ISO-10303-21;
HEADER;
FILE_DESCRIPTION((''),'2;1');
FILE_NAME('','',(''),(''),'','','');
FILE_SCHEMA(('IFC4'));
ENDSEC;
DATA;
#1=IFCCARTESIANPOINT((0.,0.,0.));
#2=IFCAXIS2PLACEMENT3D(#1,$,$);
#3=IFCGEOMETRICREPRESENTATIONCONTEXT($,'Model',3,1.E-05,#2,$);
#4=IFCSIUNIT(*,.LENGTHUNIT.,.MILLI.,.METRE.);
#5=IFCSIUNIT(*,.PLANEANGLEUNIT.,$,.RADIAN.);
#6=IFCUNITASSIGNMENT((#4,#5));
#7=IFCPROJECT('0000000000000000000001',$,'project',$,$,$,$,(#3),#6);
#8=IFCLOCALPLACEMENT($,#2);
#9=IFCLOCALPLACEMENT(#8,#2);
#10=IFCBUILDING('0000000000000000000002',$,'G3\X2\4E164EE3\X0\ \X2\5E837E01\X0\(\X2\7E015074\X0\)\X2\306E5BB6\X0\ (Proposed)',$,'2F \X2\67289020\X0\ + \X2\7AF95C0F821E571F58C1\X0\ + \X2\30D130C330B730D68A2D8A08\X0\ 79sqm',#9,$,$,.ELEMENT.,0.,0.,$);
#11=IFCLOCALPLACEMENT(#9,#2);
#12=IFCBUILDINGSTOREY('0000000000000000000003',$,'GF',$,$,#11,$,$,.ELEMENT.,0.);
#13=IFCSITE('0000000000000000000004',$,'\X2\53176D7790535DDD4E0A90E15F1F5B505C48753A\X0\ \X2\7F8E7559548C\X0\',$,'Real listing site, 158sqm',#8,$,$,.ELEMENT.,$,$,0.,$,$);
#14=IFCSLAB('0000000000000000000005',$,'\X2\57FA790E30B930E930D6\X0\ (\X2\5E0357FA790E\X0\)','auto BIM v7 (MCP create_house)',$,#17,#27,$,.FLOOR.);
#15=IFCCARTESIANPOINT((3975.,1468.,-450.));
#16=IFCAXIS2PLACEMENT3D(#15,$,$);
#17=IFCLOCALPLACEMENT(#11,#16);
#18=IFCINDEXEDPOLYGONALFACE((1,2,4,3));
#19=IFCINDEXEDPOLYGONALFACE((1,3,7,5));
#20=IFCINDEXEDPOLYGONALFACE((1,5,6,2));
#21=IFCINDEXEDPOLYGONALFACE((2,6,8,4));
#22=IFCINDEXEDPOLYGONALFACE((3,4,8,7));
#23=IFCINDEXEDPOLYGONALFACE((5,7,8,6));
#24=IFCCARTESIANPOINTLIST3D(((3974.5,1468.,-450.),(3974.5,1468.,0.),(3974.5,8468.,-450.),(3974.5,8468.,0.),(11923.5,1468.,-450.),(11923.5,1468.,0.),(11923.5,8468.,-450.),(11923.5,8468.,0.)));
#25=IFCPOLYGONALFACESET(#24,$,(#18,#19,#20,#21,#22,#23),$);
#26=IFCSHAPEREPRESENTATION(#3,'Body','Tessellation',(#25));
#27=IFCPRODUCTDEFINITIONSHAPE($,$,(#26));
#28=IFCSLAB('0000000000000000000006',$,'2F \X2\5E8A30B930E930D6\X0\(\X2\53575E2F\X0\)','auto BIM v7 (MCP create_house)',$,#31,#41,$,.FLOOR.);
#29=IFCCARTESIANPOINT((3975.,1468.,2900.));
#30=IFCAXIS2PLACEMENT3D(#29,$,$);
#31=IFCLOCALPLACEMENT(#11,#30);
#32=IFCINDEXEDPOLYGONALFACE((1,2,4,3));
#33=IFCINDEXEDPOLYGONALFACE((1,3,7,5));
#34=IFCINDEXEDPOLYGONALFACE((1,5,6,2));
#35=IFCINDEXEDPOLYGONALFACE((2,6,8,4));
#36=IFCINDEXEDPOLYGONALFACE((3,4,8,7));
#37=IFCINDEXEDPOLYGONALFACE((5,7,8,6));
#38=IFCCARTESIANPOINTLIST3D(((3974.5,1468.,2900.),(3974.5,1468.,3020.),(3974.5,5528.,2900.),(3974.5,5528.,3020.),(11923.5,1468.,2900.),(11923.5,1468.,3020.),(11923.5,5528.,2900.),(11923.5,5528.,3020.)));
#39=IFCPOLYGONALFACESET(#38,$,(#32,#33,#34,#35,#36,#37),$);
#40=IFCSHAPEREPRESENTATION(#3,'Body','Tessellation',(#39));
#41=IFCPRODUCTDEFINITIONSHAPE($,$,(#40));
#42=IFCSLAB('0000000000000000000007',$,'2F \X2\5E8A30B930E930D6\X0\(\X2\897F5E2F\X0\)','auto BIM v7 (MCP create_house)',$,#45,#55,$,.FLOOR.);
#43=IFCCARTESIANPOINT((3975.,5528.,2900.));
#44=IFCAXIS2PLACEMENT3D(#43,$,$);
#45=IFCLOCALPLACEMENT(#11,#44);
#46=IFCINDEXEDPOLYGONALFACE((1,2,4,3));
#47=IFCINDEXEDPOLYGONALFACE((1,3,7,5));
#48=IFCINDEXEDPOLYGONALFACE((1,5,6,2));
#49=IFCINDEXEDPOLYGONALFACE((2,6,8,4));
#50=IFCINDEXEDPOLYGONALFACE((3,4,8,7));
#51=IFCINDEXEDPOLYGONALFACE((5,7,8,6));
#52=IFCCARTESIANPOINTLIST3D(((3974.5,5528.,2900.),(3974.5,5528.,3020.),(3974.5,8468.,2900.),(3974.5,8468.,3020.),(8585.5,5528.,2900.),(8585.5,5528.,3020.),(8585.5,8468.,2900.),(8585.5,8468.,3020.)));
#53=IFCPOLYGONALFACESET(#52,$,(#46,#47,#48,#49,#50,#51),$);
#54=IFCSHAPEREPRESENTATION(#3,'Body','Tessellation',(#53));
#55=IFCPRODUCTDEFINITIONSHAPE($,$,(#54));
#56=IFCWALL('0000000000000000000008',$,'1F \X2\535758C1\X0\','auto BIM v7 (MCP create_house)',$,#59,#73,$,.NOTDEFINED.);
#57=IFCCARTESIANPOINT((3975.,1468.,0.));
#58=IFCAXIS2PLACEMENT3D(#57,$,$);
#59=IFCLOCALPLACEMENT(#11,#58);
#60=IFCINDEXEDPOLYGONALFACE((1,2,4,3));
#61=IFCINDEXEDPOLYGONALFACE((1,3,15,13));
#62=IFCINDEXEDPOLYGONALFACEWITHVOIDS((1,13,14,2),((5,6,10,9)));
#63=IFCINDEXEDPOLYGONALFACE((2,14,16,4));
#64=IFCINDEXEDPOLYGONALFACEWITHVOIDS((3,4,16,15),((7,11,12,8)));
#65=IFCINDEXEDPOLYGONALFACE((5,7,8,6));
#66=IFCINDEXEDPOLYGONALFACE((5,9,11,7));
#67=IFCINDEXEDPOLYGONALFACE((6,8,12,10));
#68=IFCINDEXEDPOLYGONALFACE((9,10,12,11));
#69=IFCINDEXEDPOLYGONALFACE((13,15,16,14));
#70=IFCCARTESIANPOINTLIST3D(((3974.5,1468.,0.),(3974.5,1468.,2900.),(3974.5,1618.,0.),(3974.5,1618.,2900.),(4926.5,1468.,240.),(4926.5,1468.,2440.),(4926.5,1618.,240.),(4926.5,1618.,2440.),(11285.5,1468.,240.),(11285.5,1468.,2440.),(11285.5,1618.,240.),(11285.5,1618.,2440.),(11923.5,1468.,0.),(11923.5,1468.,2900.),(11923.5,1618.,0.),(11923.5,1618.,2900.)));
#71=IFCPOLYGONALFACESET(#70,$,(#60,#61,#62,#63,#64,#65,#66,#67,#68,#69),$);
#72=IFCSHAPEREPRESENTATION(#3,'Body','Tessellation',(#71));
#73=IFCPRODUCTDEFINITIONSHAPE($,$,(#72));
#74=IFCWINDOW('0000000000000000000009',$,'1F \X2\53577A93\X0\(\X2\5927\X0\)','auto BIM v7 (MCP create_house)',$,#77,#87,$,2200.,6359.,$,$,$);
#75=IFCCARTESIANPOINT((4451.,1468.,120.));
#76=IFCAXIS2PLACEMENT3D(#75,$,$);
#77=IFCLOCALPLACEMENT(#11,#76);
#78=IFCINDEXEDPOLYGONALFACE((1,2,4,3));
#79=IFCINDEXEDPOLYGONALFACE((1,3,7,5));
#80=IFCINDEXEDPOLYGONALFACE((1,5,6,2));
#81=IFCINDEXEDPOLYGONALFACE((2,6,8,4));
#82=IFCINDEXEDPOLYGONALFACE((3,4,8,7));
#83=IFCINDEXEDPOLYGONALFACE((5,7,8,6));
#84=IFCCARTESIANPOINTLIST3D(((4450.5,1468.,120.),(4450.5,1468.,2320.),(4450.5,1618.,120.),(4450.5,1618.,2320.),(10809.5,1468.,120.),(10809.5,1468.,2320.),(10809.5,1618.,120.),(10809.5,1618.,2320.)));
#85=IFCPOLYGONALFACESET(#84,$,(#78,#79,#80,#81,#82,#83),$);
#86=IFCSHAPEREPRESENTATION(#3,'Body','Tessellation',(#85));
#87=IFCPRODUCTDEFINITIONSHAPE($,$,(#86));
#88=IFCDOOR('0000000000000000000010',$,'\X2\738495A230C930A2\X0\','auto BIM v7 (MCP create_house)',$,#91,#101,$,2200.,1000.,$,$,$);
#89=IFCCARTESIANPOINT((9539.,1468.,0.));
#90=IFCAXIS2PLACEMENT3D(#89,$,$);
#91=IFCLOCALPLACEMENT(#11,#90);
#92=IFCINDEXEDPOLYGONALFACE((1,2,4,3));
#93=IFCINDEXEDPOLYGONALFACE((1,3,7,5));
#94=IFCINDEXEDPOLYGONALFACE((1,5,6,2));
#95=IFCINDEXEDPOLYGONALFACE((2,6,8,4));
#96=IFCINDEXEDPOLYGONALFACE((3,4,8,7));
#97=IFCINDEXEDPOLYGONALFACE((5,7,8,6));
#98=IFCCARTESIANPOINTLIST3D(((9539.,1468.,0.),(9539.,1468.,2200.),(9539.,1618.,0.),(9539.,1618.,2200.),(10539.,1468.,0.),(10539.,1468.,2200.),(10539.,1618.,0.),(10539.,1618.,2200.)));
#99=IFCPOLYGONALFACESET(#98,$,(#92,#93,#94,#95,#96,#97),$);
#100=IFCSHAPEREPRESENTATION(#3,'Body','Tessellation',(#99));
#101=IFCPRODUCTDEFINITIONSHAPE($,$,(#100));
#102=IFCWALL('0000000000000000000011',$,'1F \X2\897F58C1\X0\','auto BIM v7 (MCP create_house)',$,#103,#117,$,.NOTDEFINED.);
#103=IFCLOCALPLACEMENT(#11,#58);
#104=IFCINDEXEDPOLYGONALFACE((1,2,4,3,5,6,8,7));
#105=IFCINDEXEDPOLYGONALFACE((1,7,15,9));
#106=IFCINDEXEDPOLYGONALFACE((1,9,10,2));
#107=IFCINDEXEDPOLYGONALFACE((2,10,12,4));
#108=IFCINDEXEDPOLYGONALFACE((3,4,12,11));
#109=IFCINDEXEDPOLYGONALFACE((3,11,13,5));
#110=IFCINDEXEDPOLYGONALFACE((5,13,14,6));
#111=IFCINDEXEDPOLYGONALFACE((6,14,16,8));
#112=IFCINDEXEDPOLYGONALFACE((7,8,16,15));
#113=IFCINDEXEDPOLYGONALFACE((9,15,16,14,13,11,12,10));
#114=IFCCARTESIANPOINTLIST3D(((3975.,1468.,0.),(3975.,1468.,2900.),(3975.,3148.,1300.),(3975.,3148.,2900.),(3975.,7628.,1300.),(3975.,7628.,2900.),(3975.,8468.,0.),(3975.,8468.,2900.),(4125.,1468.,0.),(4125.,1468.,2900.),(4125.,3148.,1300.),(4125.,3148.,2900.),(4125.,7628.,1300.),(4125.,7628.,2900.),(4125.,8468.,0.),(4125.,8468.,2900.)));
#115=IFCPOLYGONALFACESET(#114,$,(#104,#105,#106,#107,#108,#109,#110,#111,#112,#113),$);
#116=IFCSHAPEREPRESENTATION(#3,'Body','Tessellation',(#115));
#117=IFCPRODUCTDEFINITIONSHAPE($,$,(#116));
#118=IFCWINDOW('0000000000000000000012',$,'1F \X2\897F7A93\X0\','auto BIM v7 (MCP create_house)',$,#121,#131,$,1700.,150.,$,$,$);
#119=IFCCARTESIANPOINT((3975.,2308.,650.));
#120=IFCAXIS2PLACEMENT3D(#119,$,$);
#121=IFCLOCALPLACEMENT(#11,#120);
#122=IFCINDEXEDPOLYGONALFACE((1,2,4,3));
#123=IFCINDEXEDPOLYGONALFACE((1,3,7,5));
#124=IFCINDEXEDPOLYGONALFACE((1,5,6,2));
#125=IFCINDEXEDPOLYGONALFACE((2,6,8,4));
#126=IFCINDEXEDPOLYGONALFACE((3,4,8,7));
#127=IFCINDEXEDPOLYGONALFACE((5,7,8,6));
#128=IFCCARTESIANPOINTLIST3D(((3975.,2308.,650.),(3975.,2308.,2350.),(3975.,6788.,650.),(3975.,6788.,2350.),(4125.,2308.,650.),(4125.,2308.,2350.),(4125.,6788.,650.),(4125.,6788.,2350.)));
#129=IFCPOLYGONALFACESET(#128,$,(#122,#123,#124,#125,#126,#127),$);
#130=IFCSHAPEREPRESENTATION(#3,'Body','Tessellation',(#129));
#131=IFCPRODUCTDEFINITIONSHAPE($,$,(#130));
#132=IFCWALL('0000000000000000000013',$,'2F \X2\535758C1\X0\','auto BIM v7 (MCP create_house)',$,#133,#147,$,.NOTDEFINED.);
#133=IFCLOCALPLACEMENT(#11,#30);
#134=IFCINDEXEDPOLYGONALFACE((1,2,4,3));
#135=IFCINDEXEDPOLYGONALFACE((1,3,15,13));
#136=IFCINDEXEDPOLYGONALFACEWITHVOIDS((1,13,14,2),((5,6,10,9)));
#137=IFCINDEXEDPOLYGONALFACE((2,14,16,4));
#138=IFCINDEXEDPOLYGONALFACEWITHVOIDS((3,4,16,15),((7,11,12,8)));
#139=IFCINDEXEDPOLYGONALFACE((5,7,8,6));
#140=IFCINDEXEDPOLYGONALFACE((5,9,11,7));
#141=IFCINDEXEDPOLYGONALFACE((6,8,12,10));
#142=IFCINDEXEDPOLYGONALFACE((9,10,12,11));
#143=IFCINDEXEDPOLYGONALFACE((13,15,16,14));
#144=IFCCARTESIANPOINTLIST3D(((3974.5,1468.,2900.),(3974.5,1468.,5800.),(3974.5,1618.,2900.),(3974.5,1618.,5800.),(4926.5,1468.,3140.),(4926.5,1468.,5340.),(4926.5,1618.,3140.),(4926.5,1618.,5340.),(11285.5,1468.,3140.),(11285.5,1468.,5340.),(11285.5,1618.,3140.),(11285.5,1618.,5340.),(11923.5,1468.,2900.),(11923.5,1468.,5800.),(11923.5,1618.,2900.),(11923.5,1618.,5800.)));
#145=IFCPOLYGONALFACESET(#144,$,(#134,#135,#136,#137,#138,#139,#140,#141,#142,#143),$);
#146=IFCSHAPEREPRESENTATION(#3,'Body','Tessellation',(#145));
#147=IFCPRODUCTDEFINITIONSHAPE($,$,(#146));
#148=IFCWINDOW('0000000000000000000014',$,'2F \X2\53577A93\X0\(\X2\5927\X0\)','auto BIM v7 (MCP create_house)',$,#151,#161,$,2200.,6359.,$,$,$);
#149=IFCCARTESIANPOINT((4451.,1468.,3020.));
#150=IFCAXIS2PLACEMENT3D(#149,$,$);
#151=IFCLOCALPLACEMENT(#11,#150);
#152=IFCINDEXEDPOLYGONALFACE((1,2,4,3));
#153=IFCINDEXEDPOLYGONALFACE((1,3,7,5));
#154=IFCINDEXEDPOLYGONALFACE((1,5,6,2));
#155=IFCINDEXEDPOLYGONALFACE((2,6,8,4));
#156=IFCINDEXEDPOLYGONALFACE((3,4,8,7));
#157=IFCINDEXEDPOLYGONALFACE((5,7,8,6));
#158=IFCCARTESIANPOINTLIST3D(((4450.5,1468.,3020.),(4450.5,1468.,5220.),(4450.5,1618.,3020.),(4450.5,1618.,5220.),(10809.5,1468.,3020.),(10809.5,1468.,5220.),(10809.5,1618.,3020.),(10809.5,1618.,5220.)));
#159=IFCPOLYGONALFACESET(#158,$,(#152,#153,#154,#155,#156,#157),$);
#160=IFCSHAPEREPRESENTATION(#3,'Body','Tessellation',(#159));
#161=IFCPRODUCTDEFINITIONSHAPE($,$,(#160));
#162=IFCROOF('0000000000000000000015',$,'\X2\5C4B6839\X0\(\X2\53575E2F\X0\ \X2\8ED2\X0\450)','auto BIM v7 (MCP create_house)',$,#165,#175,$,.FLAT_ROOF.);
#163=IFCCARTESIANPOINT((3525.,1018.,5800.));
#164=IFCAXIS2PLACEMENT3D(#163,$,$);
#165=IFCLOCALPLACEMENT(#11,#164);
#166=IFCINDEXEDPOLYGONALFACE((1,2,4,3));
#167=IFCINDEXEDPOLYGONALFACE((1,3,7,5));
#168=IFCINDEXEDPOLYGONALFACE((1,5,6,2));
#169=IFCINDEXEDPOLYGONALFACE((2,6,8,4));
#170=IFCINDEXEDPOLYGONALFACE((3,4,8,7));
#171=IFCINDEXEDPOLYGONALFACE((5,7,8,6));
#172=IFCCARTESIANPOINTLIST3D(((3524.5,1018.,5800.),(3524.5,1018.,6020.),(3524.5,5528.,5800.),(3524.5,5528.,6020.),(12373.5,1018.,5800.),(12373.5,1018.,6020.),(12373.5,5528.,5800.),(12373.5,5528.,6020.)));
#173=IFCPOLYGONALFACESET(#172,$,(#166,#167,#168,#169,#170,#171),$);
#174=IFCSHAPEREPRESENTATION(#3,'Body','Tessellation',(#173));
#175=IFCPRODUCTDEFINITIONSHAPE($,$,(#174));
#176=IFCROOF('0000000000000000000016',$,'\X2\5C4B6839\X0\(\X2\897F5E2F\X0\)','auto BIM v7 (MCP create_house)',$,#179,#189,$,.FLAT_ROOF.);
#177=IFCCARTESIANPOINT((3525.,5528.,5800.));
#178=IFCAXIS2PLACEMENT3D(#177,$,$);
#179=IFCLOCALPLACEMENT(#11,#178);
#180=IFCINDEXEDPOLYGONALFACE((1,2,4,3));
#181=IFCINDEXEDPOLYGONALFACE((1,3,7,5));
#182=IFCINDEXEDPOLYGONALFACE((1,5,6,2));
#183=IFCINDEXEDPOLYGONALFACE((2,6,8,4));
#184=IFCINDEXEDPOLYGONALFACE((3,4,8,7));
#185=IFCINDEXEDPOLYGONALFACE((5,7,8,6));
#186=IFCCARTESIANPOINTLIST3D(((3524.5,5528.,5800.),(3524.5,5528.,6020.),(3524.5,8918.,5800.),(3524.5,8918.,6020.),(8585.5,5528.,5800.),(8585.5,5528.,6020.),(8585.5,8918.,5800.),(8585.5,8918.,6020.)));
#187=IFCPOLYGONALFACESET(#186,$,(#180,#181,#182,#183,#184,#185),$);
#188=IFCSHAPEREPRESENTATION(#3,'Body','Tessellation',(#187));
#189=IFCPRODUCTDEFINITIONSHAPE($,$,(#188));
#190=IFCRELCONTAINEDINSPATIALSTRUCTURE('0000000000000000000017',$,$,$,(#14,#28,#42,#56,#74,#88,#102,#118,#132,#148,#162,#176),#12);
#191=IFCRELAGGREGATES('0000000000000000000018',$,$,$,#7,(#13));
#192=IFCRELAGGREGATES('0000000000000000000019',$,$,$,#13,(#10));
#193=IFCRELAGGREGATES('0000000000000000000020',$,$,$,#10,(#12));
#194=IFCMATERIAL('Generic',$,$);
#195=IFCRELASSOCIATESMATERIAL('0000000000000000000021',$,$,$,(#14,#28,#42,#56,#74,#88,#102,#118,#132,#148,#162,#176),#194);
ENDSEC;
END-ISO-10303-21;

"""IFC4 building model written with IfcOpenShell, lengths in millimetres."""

from ifc_helpers import new_model, si_unit, frame, frame_2d, origin, place, context, project, spatial, rectangle, extrude, material, element, fill, save


model = new_model("IFC4")

# Units and contexts
model_context = context("Model", 3, precision=1e-05, world=origin())
ifc_project = project(units=[si_unit("LENGTHUNIT", "METRE", prefix="MILLI"), si_unit("PLANEANGLEUNIT", "RADIAN")], contexts=[model_context])

# Site, building, storey
site_placement = place(None, origin())
site = spatial("IfcSite", under=ifc_project, at=site_placement, Name="北海道川上郡弟子屈町 美留和", ObjectType="Real listing site, 158sqm", CompositionType="ELEMENT", RefElevation=0.0)
building_placement = place(site_placement, origin())
building = spatial("IfcBuilding", under=site, at=building_placement, Name="G3世代 広縁(縁側)の家 (Proposed)", ObjectType="2F 木造 + 竹小舞土壁 + パッシブ設計 79sqm", CompositionType="ELEMENT", ElevationOfRefHeight=0.0, ElevationOfTerrain=0.0)
storey_placement = place(building_placement, origin())
storey = spatial("IfcBuildingStorey", under=building, at=storey_placement, Name="GF", CompositionType="ELEMENT", Elevation=0.0)

# Slabs
ifc_material = material(Name="Generic")
slab_1_placement = place(storey_placement, frame((3975.0, 1468.0, -450.0)))
element("IfcSlab", 1, at=slab_1_placement, inside=storey, material=ifc_material, Name="基礎スラブ (布基礎)", Description="auto BIM v7 (MCP create_house)", PredefinedType="FLOOR", context=model_context, shape_type="SweptSolid", body=[
    extrude(rectangle(XDim=7949.0, YDim=7000.0, at=frame_2d((3974.0, 3500.0))), frame((3975.0, 1468.0, -450.0)), (0.0, 0.0, 1.0), 450.0),
])
slab_2_placement = place(storey_placement, frame((3975.0, 1468.0, 2900.0)))
element("IfcSlab", 2, at=slab_2_placement, inside=storey, material=ifc_material, Name="2F 床スラブ(南帯)", Description="auto BIM v7 (MCP create_house)", PredefinedType="FLOOR", context=model_context, shape_type="SweptSolid", body=[
    extrude(rectangle(XDim=7949.0, YDim=4060.0, at=frame_2d((3974.0, 2030.0))), frame((3975.0, 1468.0, 2900.0)), (0.0, 0.0, 1.0), 120.0),
])
slab_3_placement = place(storey_placement, frame((3975.0, 5528.0, 2900.0)))
element("IfcSlab", 3, at=slab_3_placement, inside=storey, material=ifc_material, Name="2F 床スラブ(西帯)", Description="auto BIM v7 (MCP create_house)", PredefinedType="FLOOR", context=model_context, shape_type="SweptSolid", body=[
    extrude(rectangle(XDim=4611.0, YDim=2940.0, at=frame_2d((2305.0, 1470.0))), frame((3975.0, 5528.0, 2900.0)), (0.0, 0.0, 1.0), 120.0),
])

# Wall, openings, window, door
wall_1_placement = place(storey_placement, frame((3975.0, 1468.0, 0.0)))
wall_1 = element("IfcWall", 4, at=wall_1_placement, inside=storey, material=ifc_material, Name="1F 南壁", Description="auto BIM v7 (MCP create_house)", PredefinedType="NOTDEFINED", context=model_context, shape_type="SweptSolid", body=[
    extrude(rectangle(XDim=7949.0, YDim=150.0, at=frame_2d((3974.0, 75.0))), frame((3975.0, 1468.0, 0.0)), (0.0, 0.0, 1.0), 2900.0),
])
opening_1_placement = place(storey_placement, frame((4451.0, 1468.0, 120.0)))
opening_1 = element("IfcOpeningElement", 5, at=opening_1_placement, cuts=wall_1, PredefinedType="NOTDEFINED", context=model_context, shape_type="SweptSolid", body=[
    extrude(rectangle(XDim=6359.0, YDim=150.0, at=frame_2d((3179.0, 75.0))), frame((4451.0, 1468.0, 120.0)), (0.0, 0.0, 1.0), 2200.0),
])
opening_2_placement = place(storey_placement, frame((9539.0, 1468.0, 0.0)))
opening_2 = element("IfcOpeningElement", 6, at=opening_2_placement, cuts=wall_1, PredefinedType="NOTDEFINED", context=model_context, shape_type="SweptSolid", body=[
    extrude(rectangle(XDim=1000.0, YDim=150.0, at=frame_2d((500.0, 75.0))), frame((9539.0, 1468.0, 0.0)), (0.0, 0.0, 1.0), 2200.0),
])
window_1_placement = place(storey_placement, frame((4451.0, 1468.0, 120.0)))
window_1 = element("IfcWindow", 7, at=window_1_placement, inside=storey, material=ifc_material, Name="1F 南窓(大)", Description="auto BIM v7 (MCP create_house)", OverallHeight=2200.0, OverallWidth=6359.0, context=model_context, shape_type="SweptSolid", body=[
    extrude(rectangle(XDim=6359.0, YDim=150.0, at=frame_2d((3179.0, 75.0))), frame((4451.0, 1468.0, 120.0)), (0.0, 0.0, 1.0), 2200.0),
])
fill(opening_1, window_1)
door_placement = place(storey_placement, frame((9539.0, 1468.0, 0.0)))
door = element("IfcDoor", 8, at=door_placement, inside=storey, material=ifc_material, Name="玄関ドア", Description="auto BIM v7 (MCP create_house)", OverallHeight=2200.0, OverallWidth=1000.0, context=model_context, shape_type="SweptSolid", body=[
    extrude(rectangle(XDim=1000.0, YDim=150.0, at=frame_2d((500.0, 75.0))), frame((9539.0, 1468.0, 0.0)), (0.0, 0.0, 1.0), 2200.0),
])
fill(opening_2, door)

# Wall, opening, window
wall_2_placement = place(storey_placement, frame((3975.0, 1468.0, 0.0)))
wall_2 = element("IfcWall", 9, at=wall_2_placement, inside=storey, material=ifc_material, Name="1F 西壁", Description="auto BIM v7 (MCP create_house)", PredefinedType="NOTDEFINED", context=model_context, shape_type="SweptSolid", body=[
    extrude(rectangle(XDim=150.0, YDim=7000.0, at=frame_2d((75.0, 3500.0))), frame((3975.0, 1468.0, 0.0)), (0.0, 0.0, 1.0), 2900.0),
])
opening_3_placement = place(storey_placement, frame((3975.0, 2308.0, 650.0)))
opening_3 = element("IfcOpeningElement", 10, at=opening_3_placement, cuts=wall_2, PredefinedType="NOTDEFINED", context=model_context, shape_type="SweptSolid", body=[
    extrude(rectangle(XDim=150.0, YDim=4480.0, at=frame_2d((75.0, 2240.0))), frame((3975.0, 2308.0, 650.0)), (0.0, 0.0, 1.0), 1700.0),
])
window_2_placement = place(storey_placement, frame((3975.0, 2308.0, 650.0)))
window_2 = element("IfcWindow", 11, at=window_2_placement, inside=storey, material=ifc_material, Name="1F 西窓", Description="auto BIM v7 (MCP create_house)", OverallHeight=1700.0, OverallWidth=150.0, context=model_context, shape_type="SweptSolid", body=[
    extrude(rectangle(XDim=150.0, YDim=4480.0, at=frame_2d((75.0, 2240.0))), frame((3975.0, 2308.0, 650.0)), (0.0, 0.0, 1.0), 1700.0),
])
fill(opening_3, window_2)

# Wall, opening, window
wall_3_placement = place(storey_placement, frame((3975.0, 1468.0, 2900.0)))
wall_3 = element("IfcWall", 12, at=wall_3_placement, inside=storey, material=ifc_material, Name="2F 南壁", Description="auto BIM v7 (MCP create_house)", PredefinedType="NOTDEFINED", context=model_context, shape_type="SweptSolid", body=[
    extrude(rectangle(XDim=7949.0, YDim=150.0, at=frame_2d((3974.0, 75.0))), frame((3975.0, 1468.0, 2900.0)), (0.0, 0.0, 1.0), 2900.0),
])
opening_4_placement = place(storey_placement, frame((4451.0, 1468.0, 3020.0)))
opening_4 = element("IfcOpeningElement", 13, at=opening_4_placement, cuts=wall_3, PredefinedType="NOTDEFINED", context=model_context, shape_type="SweptSolid", body=[
    extrude(rectangle(XDim=6359.0, YDim=150.0, at=frame_2d((3179.0, 75.0))), frame((4451.0, 1468.0, 3020.0)), (0.0, 0.0, 1.0), 2200.0),
])
window_3_placement = place(storey_placement, frame((4451.0, 1468.0, 3020.0)))
window_3 = element("IfcWindow", 14, at=window_3_placement, inside=storey, material=ifc_material, Name="2F 南窓(大)", Description="auto BIM v7 (MCP create_house)", OverallHeight=2200.0, OverallWidth=6359.0, context=model_context, shape_type="SweptSolid", body=[
    extrude(rectangle(XDim=6359.0, YDim=150.0, at=frame_2d((3179.0, 75.0))), frame((4451.0, 1468.0, 3020.0)), (0.0, 0.0, 1.0), 2200.0),
])
fill(opening_4, window_3)

# Roofs
roof_1_placement = place(storey_placement, frame((3525.0, 1018.0, 5800.0)))
element("IfcRoof", 15, at=roof_1_placement, inside=storey, material=ifc_material, Name="屋根(南帯 軒450)", Description="auto BIM v7 (MCP create_house)", PredefinedType="FLAT_ROOF", context=model_context, shape_type="SweptSolid", body=[
    extrude(rectangle(XDim=8849.0, YDim=4510.0, at=frame_2d((4424.0, 2255.0))), frame((3525.0, 1018.0, 5800.0)), (0.0, 0.0, 1.0), 220.0),
])
roof_2_placement = place(storey_placement, frame((3525.0, 5528.0, 5800.0)))
element("IfcRoof", 16, at=roof_2_placement, inside=storey, material=ifc_material, Name="屋根(西帯)", Description="auto BIM v7 (MCP create_house)", PredefinedType="FLAT_ROOF", context=model_context, shape_type="SweptSolid", body=[
    extrude(rectangle(XDim=5061.0, YDim=3390.0, at=frame_2d((2530.0, 1695.0))), frame((3525.0, 5528.0, 5800.0)), (0.0, 0.0, 1.0), 220.0),
])

save(model, "model.ifc")
